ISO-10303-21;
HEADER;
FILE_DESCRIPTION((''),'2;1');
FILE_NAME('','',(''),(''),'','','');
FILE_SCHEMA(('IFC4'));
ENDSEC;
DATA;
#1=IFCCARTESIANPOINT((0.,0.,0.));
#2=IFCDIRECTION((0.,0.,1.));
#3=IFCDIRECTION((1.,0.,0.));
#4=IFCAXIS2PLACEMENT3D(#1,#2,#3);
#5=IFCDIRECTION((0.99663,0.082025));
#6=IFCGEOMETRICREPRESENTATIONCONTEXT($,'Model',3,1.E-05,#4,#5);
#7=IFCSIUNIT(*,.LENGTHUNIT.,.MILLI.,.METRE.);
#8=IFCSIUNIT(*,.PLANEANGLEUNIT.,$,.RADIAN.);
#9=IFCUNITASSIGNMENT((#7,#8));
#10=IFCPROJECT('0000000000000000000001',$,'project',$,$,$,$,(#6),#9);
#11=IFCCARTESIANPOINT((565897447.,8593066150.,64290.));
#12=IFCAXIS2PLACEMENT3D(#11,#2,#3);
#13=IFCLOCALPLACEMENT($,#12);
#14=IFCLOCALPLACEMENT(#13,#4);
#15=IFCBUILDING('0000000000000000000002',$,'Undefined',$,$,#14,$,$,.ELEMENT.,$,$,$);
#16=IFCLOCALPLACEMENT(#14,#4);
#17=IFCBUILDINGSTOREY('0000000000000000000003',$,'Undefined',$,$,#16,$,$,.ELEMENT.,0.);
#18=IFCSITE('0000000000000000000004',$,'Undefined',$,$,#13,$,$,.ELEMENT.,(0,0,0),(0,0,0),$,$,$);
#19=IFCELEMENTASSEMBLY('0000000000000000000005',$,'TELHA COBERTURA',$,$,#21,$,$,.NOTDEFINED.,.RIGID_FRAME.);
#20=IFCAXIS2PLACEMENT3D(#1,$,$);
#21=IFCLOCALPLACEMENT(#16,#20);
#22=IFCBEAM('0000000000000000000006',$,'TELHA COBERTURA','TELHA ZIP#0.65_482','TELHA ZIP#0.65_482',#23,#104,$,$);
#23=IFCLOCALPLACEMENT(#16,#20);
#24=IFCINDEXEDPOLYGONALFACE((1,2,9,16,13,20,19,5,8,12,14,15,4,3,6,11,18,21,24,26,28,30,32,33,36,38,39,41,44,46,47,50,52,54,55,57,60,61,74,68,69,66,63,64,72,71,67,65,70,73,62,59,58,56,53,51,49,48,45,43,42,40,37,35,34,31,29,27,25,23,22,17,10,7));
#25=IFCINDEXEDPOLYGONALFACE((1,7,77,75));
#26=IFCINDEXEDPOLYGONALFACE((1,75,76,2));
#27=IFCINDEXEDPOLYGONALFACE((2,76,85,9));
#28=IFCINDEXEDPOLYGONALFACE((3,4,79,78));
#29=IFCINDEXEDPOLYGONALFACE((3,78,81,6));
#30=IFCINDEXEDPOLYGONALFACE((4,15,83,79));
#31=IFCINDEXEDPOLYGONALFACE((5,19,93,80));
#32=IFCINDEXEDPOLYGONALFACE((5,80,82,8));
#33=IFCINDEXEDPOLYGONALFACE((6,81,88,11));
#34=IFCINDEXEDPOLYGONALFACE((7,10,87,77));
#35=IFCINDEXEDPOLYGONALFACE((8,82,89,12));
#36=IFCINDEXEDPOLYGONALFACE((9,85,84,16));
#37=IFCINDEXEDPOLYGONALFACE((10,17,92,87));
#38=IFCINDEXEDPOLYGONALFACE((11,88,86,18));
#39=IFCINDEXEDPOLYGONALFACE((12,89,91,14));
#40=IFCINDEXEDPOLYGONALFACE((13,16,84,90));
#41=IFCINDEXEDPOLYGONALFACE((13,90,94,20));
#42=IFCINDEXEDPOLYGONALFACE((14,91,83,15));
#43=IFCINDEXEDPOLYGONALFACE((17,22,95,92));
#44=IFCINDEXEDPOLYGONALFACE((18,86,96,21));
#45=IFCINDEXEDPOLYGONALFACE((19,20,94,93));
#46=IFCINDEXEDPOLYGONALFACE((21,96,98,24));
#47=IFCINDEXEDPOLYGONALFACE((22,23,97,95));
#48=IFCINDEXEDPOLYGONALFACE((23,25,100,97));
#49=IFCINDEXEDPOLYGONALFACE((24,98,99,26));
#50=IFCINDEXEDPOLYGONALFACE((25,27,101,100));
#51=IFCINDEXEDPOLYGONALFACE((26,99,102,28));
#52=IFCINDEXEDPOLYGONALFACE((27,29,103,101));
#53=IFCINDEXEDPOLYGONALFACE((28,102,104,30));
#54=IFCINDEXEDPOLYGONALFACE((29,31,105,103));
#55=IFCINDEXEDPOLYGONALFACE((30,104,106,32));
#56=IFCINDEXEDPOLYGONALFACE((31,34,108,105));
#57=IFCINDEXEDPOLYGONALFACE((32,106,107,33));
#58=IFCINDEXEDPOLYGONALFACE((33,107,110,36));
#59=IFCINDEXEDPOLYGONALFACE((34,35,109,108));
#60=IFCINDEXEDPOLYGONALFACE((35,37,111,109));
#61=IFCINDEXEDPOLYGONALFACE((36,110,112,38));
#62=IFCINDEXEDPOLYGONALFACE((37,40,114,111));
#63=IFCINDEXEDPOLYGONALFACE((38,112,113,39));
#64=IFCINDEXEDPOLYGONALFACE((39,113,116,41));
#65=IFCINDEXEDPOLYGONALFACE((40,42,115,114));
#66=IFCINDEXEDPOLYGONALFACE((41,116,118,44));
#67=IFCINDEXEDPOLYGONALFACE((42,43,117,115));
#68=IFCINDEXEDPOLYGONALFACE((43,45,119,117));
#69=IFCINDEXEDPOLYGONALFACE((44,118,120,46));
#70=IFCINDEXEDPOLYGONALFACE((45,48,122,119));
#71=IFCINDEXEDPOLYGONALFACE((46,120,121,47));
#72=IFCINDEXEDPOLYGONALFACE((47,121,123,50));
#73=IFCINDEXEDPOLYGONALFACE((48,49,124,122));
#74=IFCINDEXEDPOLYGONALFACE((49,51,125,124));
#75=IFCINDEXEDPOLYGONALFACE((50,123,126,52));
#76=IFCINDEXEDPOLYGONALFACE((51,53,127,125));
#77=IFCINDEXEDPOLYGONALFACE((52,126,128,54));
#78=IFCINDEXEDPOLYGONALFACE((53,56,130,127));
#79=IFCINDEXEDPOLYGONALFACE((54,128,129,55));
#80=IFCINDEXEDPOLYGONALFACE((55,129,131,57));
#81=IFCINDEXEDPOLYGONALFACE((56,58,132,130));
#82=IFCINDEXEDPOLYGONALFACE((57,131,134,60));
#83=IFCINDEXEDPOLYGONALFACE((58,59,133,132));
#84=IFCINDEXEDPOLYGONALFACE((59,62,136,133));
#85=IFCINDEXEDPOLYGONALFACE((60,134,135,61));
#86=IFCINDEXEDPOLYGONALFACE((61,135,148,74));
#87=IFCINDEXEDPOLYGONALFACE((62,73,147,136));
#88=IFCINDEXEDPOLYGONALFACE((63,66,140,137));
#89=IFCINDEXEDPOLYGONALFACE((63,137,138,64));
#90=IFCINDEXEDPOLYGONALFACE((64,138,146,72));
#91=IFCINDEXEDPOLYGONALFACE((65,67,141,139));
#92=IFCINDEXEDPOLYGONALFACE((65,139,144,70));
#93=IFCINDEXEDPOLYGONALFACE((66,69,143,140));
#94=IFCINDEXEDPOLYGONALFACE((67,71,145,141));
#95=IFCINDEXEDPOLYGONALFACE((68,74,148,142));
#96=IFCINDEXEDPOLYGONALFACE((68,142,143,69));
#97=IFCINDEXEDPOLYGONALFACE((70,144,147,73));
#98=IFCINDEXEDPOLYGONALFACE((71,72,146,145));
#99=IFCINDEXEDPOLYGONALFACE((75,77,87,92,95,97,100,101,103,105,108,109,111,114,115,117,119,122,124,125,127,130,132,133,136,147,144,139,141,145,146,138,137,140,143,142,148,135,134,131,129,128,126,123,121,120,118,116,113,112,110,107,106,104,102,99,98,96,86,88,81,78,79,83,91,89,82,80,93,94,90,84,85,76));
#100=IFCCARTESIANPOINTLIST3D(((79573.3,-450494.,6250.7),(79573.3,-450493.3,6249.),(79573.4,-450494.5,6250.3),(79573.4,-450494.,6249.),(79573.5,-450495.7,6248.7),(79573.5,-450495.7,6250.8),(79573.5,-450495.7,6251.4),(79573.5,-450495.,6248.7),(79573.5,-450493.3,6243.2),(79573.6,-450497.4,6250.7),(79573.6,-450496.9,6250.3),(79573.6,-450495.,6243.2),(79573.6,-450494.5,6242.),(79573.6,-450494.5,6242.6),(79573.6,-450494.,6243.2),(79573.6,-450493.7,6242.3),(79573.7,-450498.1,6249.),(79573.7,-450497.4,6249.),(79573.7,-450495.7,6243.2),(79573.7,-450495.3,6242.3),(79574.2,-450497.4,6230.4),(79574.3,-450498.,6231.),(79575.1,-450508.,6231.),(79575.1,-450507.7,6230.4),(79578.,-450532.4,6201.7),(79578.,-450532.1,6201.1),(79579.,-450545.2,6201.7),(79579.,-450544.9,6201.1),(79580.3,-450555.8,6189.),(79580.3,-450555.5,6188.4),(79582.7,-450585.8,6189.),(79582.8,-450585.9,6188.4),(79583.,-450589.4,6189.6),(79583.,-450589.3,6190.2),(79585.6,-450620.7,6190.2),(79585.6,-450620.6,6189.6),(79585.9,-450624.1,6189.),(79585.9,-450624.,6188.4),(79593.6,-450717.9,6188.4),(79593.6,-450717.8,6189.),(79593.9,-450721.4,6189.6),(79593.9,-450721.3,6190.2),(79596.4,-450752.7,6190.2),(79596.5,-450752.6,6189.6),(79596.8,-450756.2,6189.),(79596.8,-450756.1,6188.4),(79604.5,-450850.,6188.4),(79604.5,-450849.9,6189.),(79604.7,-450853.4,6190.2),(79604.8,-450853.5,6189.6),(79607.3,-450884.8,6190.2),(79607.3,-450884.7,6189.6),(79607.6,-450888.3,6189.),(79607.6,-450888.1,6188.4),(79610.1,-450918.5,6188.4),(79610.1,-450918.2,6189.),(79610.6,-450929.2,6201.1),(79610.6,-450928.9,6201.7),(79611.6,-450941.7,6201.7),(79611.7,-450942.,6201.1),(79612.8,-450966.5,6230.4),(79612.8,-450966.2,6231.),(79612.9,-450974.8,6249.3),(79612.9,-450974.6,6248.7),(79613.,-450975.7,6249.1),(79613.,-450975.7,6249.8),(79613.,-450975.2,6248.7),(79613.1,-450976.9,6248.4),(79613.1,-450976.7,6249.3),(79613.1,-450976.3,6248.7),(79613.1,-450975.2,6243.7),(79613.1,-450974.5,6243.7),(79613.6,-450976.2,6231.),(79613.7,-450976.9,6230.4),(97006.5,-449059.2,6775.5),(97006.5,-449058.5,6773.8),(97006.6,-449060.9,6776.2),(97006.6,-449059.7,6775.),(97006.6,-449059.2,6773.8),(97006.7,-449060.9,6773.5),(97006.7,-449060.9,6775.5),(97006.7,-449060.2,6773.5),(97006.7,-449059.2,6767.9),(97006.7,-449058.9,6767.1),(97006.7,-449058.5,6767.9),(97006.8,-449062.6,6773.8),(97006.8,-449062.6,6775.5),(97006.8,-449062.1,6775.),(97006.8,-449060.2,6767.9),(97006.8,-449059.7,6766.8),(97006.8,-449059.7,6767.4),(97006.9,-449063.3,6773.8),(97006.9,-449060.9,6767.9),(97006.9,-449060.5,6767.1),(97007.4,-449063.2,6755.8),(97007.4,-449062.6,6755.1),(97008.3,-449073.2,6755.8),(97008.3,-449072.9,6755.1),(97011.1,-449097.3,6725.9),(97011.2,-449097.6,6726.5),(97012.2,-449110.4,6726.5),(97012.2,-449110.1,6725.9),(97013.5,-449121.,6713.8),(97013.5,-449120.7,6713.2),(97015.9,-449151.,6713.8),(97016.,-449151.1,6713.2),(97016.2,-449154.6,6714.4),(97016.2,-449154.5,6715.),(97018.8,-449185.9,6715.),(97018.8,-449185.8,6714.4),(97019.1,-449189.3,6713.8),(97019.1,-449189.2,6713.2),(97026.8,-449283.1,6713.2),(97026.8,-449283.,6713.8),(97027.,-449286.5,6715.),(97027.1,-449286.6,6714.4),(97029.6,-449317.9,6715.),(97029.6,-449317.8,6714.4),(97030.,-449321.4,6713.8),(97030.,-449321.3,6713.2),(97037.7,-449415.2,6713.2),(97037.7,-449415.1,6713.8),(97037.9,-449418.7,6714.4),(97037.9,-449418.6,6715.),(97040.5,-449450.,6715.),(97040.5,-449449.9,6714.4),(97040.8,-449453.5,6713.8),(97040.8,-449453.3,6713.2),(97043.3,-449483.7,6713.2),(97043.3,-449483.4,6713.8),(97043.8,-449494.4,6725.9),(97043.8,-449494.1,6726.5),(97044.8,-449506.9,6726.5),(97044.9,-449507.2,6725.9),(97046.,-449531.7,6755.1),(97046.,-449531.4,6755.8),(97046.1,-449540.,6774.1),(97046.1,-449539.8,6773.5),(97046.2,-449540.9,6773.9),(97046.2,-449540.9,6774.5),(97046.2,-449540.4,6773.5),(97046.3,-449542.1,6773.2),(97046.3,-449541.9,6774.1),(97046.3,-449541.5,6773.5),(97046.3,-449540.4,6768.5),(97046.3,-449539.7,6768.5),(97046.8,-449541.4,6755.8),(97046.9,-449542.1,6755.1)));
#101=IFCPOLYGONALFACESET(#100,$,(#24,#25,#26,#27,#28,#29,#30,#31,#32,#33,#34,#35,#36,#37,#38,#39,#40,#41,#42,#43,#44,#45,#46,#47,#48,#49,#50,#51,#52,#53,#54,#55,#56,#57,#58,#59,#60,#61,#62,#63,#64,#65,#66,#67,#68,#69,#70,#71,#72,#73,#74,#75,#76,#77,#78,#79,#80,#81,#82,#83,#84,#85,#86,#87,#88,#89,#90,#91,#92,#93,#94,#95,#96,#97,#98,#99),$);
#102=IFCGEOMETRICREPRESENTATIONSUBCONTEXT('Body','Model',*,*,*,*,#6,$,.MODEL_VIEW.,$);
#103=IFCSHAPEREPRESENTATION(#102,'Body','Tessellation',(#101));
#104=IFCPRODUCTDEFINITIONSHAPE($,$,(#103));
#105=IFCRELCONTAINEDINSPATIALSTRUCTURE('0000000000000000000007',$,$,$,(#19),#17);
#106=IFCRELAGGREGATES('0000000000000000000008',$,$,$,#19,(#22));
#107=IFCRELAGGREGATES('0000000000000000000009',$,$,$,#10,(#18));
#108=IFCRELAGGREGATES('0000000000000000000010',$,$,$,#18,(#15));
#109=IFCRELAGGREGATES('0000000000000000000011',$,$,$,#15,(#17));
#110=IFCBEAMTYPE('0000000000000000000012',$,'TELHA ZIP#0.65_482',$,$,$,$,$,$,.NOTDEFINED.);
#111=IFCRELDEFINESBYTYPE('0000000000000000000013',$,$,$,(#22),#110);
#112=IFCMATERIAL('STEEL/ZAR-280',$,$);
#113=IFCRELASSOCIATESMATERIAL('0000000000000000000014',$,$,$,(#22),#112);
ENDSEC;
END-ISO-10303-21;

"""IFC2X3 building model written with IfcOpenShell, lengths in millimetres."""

from ifc_helpers import new_model, si_unit, direction, frame, origin_with_axes, place, context, subcontext, project, spatial, polyline, outline, extrude, material, type_object, element, aggregate, save


model = new_model("IFC2X3")

# Units and contexts
model_context = context("Model", 3, precision=1e-05, world=origin_with_axes(), true_north=direction((0.99663, 0.082025)))
body_context = subcontext(model_context, "Body", "Model", "MODEL_VIEW")
ifc_project = project(units=[si_unit("LENGTHUNIT", "METRE", prefix="MILLI"), si_unit("PLANEANGLEUNIT", "RADIAN")], contexts=[model_context])

# Site, building, storey
site_placement = place(None, frame((565897447.0, 8593066150.0, 64290.0), z_axis=(0.0, 0.0, 1.0), x_axis=(1.0, 0.0, 0.0)))
site = spatial("IfcSite", under=ifc_project, at=site_placement, Name="Undefined", CompositionType="ELEMENT", RefLatitude=(0, 0, 0), RefLongitude=(0, 0, 0))
building_placement = place(site_placement, origin_with_axes())
building = spatial("IfcBuilding", under=site, at=building_placement, Name="Undefined", CompositionType="ELEMENT")
storey_placement = place(building_placement, origin_with_axes())
storey = spatial("IfcBuildingStorey", under=building, at=storey_placement, Name="Undefined", CompositionType="ELEMENT", Elevation=0.0)

# Element assembly, beam
ifc_material_1 = material(Name="STEEL/ZAR-280")
beam_type_1 = type_object("IfcBeamType", Name="TELHA ZIP#0.65_482", PredefinedType="NOTDEFINED")
assembly_1_placement = place(storey_placement, origin_with_axes())
assembly_1 = element("IfcElementAssembly", 1, at=assembly_1_placement, inside=storey, Name="TELHA COBERTURA", AssemblyPlace="NOTDEFINED", PredefinedType="RIGID_FRAME")
beam_1_placement = place(assembly_1_placement, frame((79594.1, -450735.0, 6219.6), z_axis=(-0.029885, -0.00246, 0.99955), x_axis=(0.996182, 0.081989, 0.029987)))
beam_1 = element("IfcBeam", 2, at=beam_1_placement, type_object=beam_type_1, material=ifc_material_1, Name="TELHA COBERTURA", Description="TELHA ZIP#0.65_482", ObjectType="TELHA ZIP#0.65_482", context=body_context, shape_type="SweptSolid", body=[
    extrude(outline(polyline([(240.5, 29.7), (241.4, 30.2), (242.4, 29.7), (242.6, 28.9), (242.6, 10.8), (232.2, 10.8), (207.6, -18.5), (194.9, -18.5), (184.2, -31.2), (153.7, -31.2), (150.2, -30.0), (118.9, -30.0), (115.4, -31.2), (21.2, -31.2), (17.7, -30.0), (-13.6, -30.0), (-17.1, -31.2), (-111.3, -31.2), (-114.8, -30.0), (-146.1, -30.0), (-149.6, -31.2), (-180.1, -31.2), (-190.8, -18.5), (-203.6, -18.5), (-228.1, 10.8), (-238.5, 10.8), (-238.5, 29.5), (-239.0, 30.7), (-240.2, 31.2), (-241.4, 30.7), (-241.9, 29.5), (-241.9, 23.6), (-241.4, 23.1), (-240.9, 23.6), (-240.9, 29.1), (-240.2, 29.1), (-240.2, 23.6), (-240.6, 22.8), (-241.4, 22.4), (-242.3, 22.8), (-242.6, 23.6), (-242.6, 29.5), (-241.9, 31.2), (-240.2, 31.9), (-238.5, 31.2), (-237.9, 29.5), (-237.9, 11.4), (-227.8, 11.4), (-203.2, -17.9), (-190.4, -17.9), (-179.8, -30.5), (-149.7, -30.5), (-146.2, -29.4), (-114.7, -29.4), (-111.2, -30.5), (-17.2, -30.5), (-13.7, -29.4), (17.8, -29.4), (21.3, -30.5), (115.3, -30.5), (118.8, -29.4), (150.3, -29.4), (153.8, -30.5), (183.9, -30.5), (194.6, -17.9), (207.4, -17.9), (231.9, 11.4), (241.9, 11.4), (241.9, 29.1), (241.4, 29.5), (240.9, 29.1), (240.9, 24.1), (240.2, 24.1), (240.2, 29.2), (240.5, 29.7)])), frame((17500.0, 0.0, 0.0), z_axis=(-1.0, 0.0, 0.0), x_axis=(0.0, -1.0, 0.0)), (0.0, 0.0, 1.0), 17500.0),
])
aggregate(assembly_1, [beam_1])

save(model, "model.ifc")
